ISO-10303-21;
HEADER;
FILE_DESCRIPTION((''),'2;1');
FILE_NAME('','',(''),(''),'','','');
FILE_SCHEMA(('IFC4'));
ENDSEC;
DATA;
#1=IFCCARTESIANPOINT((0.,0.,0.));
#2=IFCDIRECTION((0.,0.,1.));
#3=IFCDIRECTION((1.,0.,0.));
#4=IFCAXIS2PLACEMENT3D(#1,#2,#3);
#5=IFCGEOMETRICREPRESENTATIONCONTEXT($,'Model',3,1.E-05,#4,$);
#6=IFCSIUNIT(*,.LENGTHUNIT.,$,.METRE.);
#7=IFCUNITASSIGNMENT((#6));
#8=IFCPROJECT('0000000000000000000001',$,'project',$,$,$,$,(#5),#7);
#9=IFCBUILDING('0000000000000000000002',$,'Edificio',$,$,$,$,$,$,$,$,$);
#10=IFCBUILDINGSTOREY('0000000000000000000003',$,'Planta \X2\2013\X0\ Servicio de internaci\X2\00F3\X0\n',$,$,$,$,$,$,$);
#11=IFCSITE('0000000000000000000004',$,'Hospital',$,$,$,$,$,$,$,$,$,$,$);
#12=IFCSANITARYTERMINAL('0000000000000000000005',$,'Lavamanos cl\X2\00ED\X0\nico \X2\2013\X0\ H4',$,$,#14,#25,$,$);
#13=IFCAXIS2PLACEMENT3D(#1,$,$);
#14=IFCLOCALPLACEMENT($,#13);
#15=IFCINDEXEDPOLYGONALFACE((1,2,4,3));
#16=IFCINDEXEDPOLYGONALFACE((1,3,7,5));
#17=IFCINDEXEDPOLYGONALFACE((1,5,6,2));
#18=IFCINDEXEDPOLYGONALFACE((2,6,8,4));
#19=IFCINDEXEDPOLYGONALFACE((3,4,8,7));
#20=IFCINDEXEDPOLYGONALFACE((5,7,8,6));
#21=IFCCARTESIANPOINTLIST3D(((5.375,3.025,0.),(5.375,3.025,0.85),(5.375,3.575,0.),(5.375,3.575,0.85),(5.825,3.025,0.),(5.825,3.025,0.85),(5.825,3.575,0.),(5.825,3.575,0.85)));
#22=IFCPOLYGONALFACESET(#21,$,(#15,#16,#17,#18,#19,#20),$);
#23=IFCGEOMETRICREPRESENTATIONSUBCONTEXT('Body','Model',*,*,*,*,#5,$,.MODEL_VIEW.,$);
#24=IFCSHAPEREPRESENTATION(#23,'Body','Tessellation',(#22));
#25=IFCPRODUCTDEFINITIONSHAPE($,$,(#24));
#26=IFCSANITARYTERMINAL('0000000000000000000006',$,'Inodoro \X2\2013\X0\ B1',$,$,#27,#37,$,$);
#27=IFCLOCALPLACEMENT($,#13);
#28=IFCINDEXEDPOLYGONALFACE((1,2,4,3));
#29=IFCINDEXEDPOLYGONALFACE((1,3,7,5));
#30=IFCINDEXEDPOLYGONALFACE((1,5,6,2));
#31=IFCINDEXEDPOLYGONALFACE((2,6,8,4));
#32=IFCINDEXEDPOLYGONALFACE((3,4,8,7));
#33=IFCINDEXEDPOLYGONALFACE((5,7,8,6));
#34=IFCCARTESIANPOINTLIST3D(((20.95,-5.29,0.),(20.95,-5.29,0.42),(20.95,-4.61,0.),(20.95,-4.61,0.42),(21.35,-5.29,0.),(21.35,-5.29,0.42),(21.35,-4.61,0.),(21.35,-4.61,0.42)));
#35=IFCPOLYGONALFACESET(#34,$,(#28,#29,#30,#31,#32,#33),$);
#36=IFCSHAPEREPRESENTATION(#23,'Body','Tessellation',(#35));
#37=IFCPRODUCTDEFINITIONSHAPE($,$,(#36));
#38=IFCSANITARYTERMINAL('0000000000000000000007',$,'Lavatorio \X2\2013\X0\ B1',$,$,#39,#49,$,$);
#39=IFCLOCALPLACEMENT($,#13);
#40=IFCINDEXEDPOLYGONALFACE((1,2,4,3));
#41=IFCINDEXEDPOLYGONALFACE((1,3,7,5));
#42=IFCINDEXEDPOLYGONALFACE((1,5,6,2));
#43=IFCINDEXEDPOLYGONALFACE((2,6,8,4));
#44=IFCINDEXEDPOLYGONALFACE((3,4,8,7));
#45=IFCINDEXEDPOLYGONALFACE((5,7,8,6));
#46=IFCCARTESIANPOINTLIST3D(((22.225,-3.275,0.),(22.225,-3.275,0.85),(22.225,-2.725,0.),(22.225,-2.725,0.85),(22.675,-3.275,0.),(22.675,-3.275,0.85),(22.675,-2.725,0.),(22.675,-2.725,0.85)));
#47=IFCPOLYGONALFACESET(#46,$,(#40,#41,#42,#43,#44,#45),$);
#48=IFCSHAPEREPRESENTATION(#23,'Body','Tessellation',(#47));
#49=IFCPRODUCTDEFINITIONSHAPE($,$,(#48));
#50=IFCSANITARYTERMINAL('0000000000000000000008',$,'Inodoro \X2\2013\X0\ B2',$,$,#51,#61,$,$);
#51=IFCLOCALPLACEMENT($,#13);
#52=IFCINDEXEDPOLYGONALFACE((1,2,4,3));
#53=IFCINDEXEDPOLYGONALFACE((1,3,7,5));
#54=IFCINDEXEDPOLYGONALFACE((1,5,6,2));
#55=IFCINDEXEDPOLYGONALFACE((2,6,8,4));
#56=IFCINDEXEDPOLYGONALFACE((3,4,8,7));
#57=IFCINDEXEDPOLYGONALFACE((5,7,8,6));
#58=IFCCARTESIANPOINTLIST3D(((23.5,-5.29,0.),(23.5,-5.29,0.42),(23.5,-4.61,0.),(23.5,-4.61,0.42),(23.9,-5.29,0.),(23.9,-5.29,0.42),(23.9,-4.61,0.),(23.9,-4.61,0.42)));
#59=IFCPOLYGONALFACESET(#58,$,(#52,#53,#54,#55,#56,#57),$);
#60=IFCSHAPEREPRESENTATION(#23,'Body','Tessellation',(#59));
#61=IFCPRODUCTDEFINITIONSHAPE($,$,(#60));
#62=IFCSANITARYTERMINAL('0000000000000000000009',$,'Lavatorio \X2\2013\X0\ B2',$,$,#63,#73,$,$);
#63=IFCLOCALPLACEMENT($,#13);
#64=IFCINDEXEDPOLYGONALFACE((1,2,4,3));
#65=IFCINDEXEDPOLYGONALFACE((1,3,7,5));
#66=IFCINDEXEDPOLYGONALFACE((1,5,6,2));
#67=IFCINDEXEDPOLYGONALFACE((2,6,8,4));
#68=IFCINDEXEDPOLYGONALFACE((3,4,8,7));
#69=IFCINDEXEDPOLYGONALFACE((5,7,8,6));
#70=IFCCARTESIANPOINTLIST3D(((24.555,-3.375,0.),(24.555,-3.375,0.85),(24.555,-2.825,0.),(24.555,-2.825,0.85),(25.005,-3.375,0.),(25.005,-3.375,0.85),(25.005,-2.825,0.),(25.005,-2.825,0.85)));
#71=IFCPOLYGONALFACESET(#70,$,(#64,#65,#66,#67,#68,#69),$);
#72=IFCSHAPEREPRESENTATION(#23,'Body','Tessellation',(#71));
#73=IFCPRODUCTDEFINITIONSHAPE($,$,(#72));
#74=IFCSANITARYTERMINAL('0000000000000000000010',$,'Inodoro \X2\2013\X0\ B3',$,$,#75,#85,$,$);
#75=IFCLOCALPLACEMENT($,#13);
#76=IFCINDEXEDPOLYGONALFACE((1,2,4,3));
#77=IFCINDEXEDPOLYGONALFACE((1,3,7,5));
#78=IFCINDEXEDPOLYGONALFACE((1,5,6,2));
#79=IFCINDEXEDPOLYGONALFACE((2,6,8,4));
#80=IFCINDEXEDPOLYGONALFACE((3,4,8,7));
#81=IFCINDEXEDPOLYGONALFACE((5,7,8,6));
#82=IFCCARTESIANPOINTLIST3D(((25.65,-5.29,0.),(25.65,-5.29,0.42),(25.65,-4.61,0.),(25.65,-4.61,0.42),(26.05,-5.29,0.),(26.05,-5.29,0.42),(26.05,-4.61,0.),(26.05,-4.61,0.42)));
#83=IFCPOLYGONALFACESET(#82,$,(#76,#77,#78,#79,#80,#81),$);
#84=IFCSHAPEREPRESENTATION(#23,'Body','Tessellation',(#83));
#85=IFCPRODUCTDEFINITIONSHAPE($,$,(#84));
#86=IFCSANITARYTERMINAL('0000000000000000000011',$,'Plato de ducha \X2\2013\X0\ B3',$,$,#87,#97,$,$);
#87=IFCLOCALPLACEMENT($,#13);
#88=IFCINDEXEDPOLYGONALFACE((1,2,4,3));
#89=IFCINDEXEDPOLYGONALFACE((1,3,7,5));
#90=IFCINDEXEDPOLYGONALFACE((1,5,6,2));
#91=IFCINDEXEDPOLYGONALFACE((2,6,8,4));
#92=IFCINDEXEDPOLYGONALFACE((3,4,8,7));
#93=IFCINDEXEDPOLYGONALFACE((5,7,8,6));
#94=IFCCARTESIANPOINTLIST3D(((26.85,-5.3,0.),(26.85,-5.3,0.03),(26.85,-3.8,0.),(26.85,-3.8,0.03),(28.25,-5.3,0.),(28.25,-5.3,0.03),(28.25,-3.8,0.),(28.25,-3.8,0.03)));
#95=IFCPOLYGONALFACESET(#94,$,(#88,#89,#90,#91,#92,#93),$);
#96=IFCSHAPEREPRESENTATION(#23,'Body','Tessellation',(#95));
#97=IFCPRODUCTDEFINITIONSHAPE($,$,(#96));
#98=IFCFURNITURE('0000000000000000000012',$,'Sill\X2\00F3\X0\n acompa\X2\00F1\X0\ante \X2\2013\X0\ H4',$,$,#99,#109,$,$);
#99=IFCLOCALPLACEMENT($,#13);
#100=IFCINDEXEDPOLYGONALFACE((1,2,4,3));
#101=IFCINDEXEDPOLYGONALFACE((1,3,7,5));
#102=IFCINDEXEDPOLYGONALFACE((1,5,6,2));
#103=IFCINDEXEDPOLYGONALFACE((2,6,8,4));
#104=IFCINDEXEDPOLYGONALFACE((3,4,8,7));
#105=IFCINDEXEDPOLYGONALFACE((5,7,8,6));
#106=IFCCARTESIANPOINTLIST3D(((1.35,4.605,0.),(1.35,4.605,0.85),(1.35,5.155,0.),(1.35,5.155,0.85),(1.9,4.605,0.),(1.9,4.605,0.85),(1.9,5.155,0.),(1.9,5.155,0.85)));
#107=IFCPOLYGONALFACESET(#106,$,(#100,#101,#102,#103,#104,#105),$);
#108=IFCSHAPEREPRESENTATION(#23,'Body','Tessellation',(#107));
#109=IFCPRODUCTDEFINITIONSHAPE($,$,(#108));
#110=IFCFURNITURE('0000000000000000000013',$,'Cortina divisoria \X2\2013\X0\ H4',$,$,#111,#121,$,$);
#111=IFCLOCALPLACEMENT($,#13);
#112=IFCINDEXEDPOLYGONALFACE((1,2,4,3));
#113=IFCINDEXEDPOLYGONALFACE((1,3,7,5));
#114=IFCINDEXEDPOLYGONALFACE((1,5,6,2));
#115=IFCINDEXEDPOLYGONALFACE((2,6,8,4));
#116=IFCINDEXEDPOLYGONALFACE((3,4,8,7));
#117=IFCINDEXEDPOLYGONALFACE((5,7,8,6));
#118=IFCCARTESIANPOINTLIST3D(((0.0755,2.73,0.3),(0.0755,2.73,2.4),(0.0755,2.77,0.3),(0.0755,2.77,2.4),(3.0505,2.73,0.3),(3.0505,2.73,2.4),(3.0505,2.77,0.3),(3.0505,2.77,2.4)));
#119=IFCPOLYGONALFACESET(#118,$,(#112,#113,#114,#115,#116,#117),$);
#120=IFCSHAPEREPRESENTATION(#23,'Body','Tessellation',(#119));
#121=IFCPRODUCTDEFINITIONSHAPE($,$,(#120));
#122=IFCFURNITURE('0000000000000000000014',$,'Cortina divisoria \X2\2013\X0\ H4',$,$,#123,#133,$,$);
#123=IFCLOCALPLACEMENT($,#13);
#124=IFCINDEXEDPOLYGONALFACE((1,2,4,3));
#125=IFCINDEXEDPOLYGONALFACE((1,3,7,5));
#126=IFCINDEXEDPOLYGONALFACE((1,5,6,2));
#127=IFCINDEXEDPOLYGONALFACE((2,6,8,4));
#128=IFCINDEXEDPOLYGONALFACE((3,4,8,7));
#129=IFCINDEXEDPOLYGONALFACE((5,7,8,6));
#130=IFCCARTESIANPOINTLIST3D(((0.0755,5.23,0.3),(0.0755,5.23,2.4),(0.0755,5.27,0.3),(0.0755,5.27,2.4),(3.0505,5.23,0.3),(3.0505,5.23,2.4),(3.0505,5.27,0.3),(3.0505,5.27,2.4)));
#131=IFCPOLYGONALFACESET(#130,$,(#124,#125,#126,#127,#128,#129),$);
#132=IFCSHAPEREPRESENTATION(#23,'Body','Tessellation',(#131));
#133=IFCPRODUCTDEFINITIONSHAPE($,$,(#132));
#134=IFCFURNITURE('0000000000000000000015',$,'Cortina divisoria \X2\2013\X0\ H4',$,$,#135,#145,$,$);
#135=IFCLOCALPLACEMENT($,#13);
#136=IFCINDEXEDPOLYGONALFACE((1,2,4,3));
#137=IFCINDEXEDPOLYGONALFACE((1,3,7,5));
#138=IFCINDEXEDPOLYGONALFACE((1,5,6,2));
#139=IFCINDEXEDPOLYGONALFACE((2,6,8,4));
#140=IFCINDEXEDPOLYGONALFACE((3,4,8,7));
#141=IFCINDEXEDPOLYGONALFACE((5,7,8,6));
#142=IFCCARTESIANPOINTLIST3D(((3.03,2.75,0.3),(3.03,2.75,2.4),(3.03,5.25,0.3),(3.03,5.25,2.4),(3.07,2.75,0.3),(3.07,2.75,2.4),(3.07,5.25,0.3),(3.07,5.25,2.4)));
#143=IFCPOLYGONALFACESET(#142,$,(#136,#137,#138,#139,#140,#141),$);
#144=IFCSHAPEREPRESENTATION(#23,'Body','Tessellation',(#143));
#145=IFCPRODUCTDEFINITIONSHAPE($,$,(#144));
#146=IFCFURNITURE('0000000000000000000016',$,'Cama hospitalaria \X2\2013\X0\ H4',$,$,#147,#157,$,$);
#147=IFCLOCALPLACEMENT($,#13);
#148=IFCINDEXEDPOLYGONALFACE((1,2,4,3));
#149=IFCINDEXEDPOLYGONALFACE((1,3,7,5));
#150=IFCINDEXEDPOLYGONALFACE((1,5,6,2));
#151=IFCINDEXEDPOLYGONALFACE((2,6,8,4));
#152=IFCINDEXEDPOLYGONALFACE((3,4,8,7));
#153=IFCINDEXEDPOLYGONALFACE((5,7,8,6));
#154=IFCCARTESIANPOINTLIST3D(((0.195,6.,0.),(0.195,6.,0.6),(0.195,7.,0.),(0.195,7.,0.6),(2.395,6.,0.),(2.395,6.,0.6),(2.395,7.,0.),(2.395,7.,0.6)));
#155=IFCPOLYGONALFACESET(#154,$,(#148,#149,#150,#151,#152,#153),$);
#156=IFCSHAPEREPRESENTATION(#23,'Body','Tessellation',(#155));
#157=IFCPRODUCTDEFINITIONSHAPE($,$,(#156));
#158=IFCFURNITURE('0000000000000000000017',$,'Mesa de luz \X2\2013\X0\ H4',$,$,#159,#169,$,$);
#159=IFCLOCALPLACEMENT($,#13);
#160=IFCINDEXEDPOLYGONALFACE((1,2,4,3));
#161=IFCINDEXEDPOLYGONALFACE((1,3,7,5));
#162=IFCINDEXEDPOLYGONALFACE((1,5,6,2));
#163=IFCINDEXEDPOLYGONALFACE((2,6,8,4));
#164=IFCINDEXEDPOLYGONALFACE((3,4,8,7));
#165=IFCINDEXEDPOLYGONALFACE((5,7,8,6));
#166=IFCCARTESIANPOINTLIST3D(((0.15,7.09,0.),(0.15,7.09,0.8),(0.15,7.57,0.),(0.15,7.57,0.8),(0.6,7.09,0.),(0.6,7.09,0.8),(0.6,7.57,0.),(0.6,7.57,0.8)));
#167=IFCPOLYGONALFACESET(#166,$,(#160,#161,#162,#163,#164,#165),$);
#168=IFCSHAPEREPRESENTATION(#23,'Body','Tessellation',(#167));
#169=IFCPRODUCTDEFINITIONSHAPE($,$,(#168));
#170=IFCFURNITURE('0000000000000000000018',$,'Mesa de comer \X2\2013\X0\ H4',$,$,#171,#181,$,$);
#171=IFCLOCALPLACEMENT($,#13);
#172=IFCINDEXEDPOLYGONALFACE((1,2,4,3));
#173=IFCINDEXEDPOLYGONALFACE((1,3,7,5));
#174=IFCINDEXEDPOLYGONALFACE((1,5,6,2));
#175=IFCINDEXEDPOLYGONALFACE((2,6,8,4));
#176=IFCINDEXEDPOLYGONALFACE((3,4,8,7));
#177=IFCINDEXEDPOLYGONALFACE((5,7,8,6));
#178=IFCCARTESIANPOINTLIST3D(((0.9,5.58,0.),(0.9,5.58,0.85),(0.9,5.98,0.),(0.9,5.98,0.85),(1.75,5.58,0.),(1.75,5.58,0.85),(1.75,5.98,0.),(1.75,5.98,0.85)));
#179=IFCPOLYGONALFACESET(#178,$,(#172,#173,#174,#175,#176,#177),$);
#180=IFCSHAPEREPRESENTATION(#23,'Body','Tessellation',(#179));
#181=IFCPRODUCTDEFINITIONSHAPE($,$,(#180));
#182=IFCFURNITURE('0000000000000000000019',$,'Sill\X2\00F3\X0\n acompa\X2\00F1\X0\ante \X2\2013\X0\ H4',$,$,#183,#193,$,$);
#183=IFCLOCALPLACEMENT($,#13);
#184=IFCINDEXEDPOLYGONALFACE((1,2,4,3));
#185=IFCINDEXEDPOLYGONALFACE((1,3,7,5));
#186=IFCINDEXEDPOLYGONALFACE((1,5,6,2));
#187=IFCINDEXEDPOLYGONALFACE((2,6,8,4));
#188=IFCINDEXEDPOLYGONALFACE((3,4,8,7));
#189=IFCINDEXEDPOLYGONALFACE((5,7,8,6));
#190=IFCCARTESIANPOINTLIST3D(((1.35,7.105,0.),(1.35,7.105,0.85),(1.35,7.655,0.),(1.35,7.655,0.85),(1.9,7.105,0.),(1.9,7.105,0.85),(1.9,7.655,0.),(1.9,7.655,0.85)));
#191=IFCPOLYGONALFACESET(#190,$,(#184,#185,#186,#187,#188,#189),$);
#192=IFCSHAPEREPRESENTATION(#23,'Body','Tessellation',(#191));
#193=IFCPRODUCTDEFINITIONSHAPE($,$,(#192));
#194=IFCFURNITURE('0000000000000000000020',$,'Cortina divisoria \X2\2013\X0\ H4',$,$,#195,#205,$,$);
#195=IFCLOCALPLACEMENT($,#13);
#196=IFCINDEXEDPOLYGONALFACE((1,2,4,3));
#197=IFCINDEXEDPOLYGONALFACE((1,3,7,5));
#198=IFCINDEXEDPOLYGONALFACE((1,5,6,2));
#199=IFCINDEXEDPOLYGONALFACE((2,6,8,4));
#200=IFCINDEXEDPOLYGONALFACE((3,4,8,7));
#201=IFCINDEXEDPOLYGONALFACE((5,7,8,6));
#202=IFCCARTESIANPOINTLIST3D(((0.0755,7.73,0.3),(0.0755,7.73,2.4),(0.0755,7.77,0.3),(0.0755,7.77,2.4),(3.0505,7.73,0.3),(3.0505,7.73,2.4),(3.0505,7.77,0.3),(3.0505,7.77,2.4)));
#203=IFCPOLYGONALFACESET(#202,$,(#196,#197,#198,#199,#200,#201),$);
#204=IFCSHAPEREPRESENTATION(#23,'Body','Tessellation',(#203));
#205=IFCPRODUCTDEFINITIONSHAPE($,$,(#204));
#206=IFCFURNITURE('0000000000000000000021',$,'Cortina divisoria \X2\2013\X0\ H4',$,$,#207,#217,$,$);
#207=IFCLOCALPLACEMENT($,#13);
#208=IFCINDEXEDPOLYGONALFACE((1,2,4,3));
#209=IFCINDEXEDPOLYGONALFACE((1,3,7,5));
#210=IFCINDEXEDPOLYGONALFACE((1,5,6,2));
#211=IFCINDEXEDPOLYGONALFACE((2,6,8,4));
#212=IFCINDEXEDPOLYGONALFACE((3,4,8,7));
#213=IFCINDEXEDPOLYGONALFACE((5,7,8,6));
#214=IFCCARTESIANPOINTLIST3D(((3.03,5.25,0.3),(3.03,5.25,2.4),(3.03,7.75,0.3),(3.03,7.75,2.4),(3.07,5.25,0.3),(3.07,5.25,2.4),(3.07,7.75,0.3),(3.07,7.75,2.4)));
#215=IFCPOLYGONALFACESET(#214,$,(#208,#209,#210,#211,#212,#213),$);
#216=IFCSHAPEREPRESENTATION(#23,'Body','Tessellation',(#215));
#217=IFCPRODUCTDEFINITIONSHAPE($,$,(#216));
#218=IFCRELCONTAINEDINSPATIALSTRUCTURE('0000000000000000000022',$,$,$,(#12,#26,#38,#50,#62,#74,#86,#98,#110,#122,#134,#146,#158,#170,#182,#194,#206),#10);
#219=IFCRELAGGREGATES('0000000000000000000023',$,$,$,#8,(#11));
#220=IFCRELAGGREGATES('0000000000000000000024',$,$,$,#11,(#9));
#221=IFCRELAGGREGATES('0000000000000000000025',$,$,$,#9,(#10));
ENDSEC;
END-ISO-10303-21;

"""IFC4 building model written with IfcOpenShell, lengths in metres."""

from ifc_helpers import new_model, si_unit, frame, origin_with_axes, context, subcontext, project, spatial, line, indexed_curve, outline, extrude, element, save


model = new_model("IFC4")

# Units and contexts
model_context = context("Model", 3, precision=1e-05, world=origin_with_axes())
body_context = subcontext(model_context, "Body", "Model", "MODEL_VIEW")
ifc_project = project(units=[si_unit("LENGTHUNIT", "METRE")], contexts=[model_context])

# Site, building, storey
site = spatial("IfcSite", under=ifc_project, Name="Hospital")
building = spatial("IfcBuilding", under=site, Name="Edificio")
storey = spatial("IfcBuildingStorey", under=building, Name="Planta – Servicio de internación")

# Sanitary terminals
element("IfcSanitaryTerminal", 1, inside=storey, Name="Lavamanos clínico – H4", context=body_context, shape_type="SweptSolid", body=[
    extrude(outline(indexed_curve([(0.0, 0.0), (0.45, 0.0), (0.45, 0.55), (0.0, 0.55)], segments=[line(1, 2, 3, 4, 1)])), frame((5.375, 3.025, 0.0), z_axis=(0.0, 0.0, 1.0), x_axis=(1.0, 0.0, 0.0)), (0.0, 0.0, 1.0), 0.85),
])
element("IfcSanitaryTerminal", 2, inside=storey, Name="Inodoro – B1", context=body_context, shape_type="SweptSolid", body=[
    extrude(outline(indexed_curve([(0.0, 0.0), (0.4, 0.0), (0.4, 0.68), (0.0, 0.68)], segments=[line(1, 2, 3, 4, 1)])), frame((20.95, -5.29, 0.0), z_axis=(0.0, 0.0, 1.0), x_axis=(1.0, 0.0, 0.0)), (0.0, 0.0, 1.0), 0.42),
])
element("IfcSanitaryTerminal", 3, inside=storey, Name="Lavatorio – B1", context=body_context, shape_type="SweptSolid", body=[
    extrude(outline(indexed_curve([(0.0, 0.0), (0.45, 0.0), (0.45, 0.55), (0.0, 0.55)], segments=[line(1, 2, 3, 4, 1)])), frame((22.225, -3.275, 0.0), z_axis=(0.0, 0.0, 1.0), x_axis=(1.0, 0.0, 0.0)), (0.0, 0.0, 1.0), 0.85),
])
element("IfcSanitaryTerminal", 4, inside=storey, Name="Inodoro – B2", context=body_context, shape_type="SweptSolid", body=[
    extrude(outline(indexed_curve([(0.0, 0.0), (0.4, 0.0), (0.4, 0.68), (0.0, 0.68)], segments=[line(1, 2, 3, 4, 1)])), frame((23.5, -5.29, 0.0), z_axis=(0.0, 0.0, 1.0), x_axis=(1.0, 0.0, 0.0)), (0.0, 0.0, 1.0), 0.42),
])
element("IfcSanitaryTerminal", 5, inside=storey, Name="Lavatorio – B2", context=body_context, shape_type="SweptSolid", body=[
    extrude(outline(indexed_curve([(0.0, 0.0), (0.45, 0.0), (0.45, 0.55), (0.0, 0.55)], segments=[line(1, 2, 3, 4, 1)])), frame((24.555, -3.375, 0.0), z_axis=(0.0, 0.0, 1.0), x_axis=(1.0, 0.0, 0.0)), (0.0, 0.0, 1.0), 0.85),
])
element("IfcSanitaryTerminal", 6, inside=storey, Name="Inodoro – B3", context=body_context, shape_type="SweptSolid", body=[
    extrude(outline(indexed_curve([(0.0, 0.0), (0.4, 0.0), (0.4, 0.68), (0.0, 0.68)], segments=[line(1, 2, 3, 4, 1)])), frame((25.65, -5.29, 0.0), z_axis=(0.0, 0.0, 1.0), x_axis=(1.0, 0.0, 0.0)), (0.0, 0.0, 1.0), 0.42),
])
element("IfcSanitaryTerminal", 7, inside=storey, Name="Plato de ducha – B3", context=body_context, shape_type="SweptSolid", body=[
    extrude(outline(indexed_curve([(0.0, 0.0), (1.4, 0.0), (1.4, 1.5), (0.0, 1.5)], segments=[line(1, 2, 3, 4, 1)])), frame((26.85, -5.3, 0.0), z_axis=(0.0, 0.0, 1.0), x_axis=(1.0, 0.0, 0.0)), (0.0, 0.0, 1.0), 0.03),
])

# Furniture
element("IfcFurniture", 8, inside=storey, Name="Sillón acompañante – H4", context=body_context, shape_type="SweptSolid", body=[
    extrude(outline(indexed_curve([(0.0, 0.0), (0.55, 0.0), (0.55, 0.55), (0.0, 0.55)], segments=[line(1, 2, 3, 4, 1)])), frame((1.35, 4.605, 0.0), z_axis=(0.0, 0.0, 1.0), x_axis=(1.0, 0.0, 0.0)), (0.0, 0.0, 1.0), 0.85),
])
element("IfcFurniture", 9, inside=storey, Name="Cortina divisoria – H4", context=body_context, shape_type="SweptSolid", body=[
    extrude(outline(indexed_curve([(0.0, 0.0), (2.975, 0.0), (2.975, 0.04), (0.0, 0.04)], segments=[line(1, 2, 3, 4, 1)])), frame((0.0755, 2.73, 0.3), z_axis=(0.0, 0.0, 1.0), x_axis=(1.0, 0.0, 0.0)), (0.0, 0.0, 1.0), 2.1),
])
element("IfcFurniture", 10, inside=storey, Name="Cortina divisoria – H4", context=body_context, shape_type="SweptSolid", body=[
    extrude(outline(indexed_curve([(0.0, 0.0), (2.975, 0.0), (2.975, 0.04), (0.0, 0.04)], segments=[line(1, 2, 3, 4, 1)])), frame((0.0755, 5.23, 0.3), z_axis=(0.0, 0.0, 1.0), x_axis=(1.0, 0.0, 0.0)), (0.0, 0.0, 1.0), 2.1),
])
element("IfcFurniture", 11, inside=storey, Name="Cortina divisoria – H4", context=body_context, shape_type="SweptSolid", body=[
    extrude(outline(indexed_curve([(0.0, 0.0), (0.04, 0.0), (0.04, 2.5), (0.0, 2.5)], segments=[line(1, 2, 3, 4, 1)])), frame((3.03, 2.75, 0.3), z_axis=(0.0, 0.0, 1.0), x_axis=(1.0, 0.0, 0.0)), (0.0, 0.0, 1.0), 2.1),
])
element("IfcFurniture", 12, inside=storey, Name="Cama hospitalaria – H4", context=body_context, shape_type="SweptSolid", body=[
    extrude(outline(indexed_curve([(0.0, 0.0), (2.2, 0.0), (2.2, 1.0), (0.0, 1.0)], segments=[line(1, 2, 3, 4, 1)])), frame((0.195, 6.0, 0.0), z_axis=(0.0, 0.0, 1.0), x_axis=(1.0, 0.0, 0.0)), (0.0, 0.0, 1.0), 0.6),
])
element("IfcFurniture", 13, inside=storey, Name="Mesa de luz – H4", context=body_context, shape_type="SweptSolid", body=[
    extrude(outline(indexed_curve([(0.0, 0.0), (0.45, 0.0), (0.45, 0.48), (0.0, 0.48)], segments=[line(1, 2, 3, 4, 1)])), frame((0.15, 7.09, 0.0), z_axis=(0.0, 0.0, 1.0), x_axis=(1.0, 0.0, 0.0)), (0.0, 0.0, 1.0), 0.8),
])
element("IfcFurniture", 14, inside=storey, Name="Mesa de comer – H4", context=body_context, shape_type="SweptSolid", body=[
    extrude(outline(indexed_curve([(0.0, 0.0), (0.85, 0.0), (0.85, 0.4), (0.0, 0.4)], segments=[line(1, 2, 3, 4, 1)])), frame((0.9, 5.58, 0.0), z_axis=(0.0, 0.0, 1.0), x_axis=(1.0, 0.0, 0.0)), (0.0, 0.0, 1.0), 0.85),
])
element("IfcFurniture", 15, inside=storey, Name="Sillón acompañante – H4", context=body_context, shape_type="SweptSolid", body=[
    extrude(outline(indexed_curve([(0.0, 0.0), (0.55, 0.0), (0.55, 0.55), (0.0, 0.55)], segments=[line(1, 2, 3, 4, 1)])), frame((1.35, 7.105, 0.0), z_axis=(0.0, 0.0, 1.0), x_axis=(1.0, 0.0, 0.0)), (0.0, 0.0, 1.0), 0.85),
])
element("IfcFurniture", 16, inside=storey, Name="Cortina divisoria – H4", context=body_context, shape_type="SweptSolid", body=[
    extrude(outline(indexed_curve([(0.0, 0.0), (2.975, 0.0), (2.975, 0.04), (0.0, 0.04)], segments=[line(1, 2, 3, 4, 1)])), frame((0.0755, 7.73, 0.3), z_axis=(0.0, 0.0, 1.0), x_axis=(1.0, 0.0, 0.0)), (0.0, 0.0, 1.0), 2.1),
])
element("IfcFurniture", 17, inside=storey, Name="Cortina divisoria – H4", context=body_context, shape_type="SweptSolid", body=[
    extrude(outline(indexed_curve([(0.0, 0.0), (0.04, 0.0), (0.04, 2.5), (0.0, 2.5)], segments=[line(1, 2, 3, 4, 1)])), frame((3.03, 5.25, 0.3), z_axis=(0.0, 0.0, 1.0), x_axis=(1.0, 0.0, 0.0)), (0.0, 0.0, 1.0), 2.1),
])

save(model, "model.ifc")
